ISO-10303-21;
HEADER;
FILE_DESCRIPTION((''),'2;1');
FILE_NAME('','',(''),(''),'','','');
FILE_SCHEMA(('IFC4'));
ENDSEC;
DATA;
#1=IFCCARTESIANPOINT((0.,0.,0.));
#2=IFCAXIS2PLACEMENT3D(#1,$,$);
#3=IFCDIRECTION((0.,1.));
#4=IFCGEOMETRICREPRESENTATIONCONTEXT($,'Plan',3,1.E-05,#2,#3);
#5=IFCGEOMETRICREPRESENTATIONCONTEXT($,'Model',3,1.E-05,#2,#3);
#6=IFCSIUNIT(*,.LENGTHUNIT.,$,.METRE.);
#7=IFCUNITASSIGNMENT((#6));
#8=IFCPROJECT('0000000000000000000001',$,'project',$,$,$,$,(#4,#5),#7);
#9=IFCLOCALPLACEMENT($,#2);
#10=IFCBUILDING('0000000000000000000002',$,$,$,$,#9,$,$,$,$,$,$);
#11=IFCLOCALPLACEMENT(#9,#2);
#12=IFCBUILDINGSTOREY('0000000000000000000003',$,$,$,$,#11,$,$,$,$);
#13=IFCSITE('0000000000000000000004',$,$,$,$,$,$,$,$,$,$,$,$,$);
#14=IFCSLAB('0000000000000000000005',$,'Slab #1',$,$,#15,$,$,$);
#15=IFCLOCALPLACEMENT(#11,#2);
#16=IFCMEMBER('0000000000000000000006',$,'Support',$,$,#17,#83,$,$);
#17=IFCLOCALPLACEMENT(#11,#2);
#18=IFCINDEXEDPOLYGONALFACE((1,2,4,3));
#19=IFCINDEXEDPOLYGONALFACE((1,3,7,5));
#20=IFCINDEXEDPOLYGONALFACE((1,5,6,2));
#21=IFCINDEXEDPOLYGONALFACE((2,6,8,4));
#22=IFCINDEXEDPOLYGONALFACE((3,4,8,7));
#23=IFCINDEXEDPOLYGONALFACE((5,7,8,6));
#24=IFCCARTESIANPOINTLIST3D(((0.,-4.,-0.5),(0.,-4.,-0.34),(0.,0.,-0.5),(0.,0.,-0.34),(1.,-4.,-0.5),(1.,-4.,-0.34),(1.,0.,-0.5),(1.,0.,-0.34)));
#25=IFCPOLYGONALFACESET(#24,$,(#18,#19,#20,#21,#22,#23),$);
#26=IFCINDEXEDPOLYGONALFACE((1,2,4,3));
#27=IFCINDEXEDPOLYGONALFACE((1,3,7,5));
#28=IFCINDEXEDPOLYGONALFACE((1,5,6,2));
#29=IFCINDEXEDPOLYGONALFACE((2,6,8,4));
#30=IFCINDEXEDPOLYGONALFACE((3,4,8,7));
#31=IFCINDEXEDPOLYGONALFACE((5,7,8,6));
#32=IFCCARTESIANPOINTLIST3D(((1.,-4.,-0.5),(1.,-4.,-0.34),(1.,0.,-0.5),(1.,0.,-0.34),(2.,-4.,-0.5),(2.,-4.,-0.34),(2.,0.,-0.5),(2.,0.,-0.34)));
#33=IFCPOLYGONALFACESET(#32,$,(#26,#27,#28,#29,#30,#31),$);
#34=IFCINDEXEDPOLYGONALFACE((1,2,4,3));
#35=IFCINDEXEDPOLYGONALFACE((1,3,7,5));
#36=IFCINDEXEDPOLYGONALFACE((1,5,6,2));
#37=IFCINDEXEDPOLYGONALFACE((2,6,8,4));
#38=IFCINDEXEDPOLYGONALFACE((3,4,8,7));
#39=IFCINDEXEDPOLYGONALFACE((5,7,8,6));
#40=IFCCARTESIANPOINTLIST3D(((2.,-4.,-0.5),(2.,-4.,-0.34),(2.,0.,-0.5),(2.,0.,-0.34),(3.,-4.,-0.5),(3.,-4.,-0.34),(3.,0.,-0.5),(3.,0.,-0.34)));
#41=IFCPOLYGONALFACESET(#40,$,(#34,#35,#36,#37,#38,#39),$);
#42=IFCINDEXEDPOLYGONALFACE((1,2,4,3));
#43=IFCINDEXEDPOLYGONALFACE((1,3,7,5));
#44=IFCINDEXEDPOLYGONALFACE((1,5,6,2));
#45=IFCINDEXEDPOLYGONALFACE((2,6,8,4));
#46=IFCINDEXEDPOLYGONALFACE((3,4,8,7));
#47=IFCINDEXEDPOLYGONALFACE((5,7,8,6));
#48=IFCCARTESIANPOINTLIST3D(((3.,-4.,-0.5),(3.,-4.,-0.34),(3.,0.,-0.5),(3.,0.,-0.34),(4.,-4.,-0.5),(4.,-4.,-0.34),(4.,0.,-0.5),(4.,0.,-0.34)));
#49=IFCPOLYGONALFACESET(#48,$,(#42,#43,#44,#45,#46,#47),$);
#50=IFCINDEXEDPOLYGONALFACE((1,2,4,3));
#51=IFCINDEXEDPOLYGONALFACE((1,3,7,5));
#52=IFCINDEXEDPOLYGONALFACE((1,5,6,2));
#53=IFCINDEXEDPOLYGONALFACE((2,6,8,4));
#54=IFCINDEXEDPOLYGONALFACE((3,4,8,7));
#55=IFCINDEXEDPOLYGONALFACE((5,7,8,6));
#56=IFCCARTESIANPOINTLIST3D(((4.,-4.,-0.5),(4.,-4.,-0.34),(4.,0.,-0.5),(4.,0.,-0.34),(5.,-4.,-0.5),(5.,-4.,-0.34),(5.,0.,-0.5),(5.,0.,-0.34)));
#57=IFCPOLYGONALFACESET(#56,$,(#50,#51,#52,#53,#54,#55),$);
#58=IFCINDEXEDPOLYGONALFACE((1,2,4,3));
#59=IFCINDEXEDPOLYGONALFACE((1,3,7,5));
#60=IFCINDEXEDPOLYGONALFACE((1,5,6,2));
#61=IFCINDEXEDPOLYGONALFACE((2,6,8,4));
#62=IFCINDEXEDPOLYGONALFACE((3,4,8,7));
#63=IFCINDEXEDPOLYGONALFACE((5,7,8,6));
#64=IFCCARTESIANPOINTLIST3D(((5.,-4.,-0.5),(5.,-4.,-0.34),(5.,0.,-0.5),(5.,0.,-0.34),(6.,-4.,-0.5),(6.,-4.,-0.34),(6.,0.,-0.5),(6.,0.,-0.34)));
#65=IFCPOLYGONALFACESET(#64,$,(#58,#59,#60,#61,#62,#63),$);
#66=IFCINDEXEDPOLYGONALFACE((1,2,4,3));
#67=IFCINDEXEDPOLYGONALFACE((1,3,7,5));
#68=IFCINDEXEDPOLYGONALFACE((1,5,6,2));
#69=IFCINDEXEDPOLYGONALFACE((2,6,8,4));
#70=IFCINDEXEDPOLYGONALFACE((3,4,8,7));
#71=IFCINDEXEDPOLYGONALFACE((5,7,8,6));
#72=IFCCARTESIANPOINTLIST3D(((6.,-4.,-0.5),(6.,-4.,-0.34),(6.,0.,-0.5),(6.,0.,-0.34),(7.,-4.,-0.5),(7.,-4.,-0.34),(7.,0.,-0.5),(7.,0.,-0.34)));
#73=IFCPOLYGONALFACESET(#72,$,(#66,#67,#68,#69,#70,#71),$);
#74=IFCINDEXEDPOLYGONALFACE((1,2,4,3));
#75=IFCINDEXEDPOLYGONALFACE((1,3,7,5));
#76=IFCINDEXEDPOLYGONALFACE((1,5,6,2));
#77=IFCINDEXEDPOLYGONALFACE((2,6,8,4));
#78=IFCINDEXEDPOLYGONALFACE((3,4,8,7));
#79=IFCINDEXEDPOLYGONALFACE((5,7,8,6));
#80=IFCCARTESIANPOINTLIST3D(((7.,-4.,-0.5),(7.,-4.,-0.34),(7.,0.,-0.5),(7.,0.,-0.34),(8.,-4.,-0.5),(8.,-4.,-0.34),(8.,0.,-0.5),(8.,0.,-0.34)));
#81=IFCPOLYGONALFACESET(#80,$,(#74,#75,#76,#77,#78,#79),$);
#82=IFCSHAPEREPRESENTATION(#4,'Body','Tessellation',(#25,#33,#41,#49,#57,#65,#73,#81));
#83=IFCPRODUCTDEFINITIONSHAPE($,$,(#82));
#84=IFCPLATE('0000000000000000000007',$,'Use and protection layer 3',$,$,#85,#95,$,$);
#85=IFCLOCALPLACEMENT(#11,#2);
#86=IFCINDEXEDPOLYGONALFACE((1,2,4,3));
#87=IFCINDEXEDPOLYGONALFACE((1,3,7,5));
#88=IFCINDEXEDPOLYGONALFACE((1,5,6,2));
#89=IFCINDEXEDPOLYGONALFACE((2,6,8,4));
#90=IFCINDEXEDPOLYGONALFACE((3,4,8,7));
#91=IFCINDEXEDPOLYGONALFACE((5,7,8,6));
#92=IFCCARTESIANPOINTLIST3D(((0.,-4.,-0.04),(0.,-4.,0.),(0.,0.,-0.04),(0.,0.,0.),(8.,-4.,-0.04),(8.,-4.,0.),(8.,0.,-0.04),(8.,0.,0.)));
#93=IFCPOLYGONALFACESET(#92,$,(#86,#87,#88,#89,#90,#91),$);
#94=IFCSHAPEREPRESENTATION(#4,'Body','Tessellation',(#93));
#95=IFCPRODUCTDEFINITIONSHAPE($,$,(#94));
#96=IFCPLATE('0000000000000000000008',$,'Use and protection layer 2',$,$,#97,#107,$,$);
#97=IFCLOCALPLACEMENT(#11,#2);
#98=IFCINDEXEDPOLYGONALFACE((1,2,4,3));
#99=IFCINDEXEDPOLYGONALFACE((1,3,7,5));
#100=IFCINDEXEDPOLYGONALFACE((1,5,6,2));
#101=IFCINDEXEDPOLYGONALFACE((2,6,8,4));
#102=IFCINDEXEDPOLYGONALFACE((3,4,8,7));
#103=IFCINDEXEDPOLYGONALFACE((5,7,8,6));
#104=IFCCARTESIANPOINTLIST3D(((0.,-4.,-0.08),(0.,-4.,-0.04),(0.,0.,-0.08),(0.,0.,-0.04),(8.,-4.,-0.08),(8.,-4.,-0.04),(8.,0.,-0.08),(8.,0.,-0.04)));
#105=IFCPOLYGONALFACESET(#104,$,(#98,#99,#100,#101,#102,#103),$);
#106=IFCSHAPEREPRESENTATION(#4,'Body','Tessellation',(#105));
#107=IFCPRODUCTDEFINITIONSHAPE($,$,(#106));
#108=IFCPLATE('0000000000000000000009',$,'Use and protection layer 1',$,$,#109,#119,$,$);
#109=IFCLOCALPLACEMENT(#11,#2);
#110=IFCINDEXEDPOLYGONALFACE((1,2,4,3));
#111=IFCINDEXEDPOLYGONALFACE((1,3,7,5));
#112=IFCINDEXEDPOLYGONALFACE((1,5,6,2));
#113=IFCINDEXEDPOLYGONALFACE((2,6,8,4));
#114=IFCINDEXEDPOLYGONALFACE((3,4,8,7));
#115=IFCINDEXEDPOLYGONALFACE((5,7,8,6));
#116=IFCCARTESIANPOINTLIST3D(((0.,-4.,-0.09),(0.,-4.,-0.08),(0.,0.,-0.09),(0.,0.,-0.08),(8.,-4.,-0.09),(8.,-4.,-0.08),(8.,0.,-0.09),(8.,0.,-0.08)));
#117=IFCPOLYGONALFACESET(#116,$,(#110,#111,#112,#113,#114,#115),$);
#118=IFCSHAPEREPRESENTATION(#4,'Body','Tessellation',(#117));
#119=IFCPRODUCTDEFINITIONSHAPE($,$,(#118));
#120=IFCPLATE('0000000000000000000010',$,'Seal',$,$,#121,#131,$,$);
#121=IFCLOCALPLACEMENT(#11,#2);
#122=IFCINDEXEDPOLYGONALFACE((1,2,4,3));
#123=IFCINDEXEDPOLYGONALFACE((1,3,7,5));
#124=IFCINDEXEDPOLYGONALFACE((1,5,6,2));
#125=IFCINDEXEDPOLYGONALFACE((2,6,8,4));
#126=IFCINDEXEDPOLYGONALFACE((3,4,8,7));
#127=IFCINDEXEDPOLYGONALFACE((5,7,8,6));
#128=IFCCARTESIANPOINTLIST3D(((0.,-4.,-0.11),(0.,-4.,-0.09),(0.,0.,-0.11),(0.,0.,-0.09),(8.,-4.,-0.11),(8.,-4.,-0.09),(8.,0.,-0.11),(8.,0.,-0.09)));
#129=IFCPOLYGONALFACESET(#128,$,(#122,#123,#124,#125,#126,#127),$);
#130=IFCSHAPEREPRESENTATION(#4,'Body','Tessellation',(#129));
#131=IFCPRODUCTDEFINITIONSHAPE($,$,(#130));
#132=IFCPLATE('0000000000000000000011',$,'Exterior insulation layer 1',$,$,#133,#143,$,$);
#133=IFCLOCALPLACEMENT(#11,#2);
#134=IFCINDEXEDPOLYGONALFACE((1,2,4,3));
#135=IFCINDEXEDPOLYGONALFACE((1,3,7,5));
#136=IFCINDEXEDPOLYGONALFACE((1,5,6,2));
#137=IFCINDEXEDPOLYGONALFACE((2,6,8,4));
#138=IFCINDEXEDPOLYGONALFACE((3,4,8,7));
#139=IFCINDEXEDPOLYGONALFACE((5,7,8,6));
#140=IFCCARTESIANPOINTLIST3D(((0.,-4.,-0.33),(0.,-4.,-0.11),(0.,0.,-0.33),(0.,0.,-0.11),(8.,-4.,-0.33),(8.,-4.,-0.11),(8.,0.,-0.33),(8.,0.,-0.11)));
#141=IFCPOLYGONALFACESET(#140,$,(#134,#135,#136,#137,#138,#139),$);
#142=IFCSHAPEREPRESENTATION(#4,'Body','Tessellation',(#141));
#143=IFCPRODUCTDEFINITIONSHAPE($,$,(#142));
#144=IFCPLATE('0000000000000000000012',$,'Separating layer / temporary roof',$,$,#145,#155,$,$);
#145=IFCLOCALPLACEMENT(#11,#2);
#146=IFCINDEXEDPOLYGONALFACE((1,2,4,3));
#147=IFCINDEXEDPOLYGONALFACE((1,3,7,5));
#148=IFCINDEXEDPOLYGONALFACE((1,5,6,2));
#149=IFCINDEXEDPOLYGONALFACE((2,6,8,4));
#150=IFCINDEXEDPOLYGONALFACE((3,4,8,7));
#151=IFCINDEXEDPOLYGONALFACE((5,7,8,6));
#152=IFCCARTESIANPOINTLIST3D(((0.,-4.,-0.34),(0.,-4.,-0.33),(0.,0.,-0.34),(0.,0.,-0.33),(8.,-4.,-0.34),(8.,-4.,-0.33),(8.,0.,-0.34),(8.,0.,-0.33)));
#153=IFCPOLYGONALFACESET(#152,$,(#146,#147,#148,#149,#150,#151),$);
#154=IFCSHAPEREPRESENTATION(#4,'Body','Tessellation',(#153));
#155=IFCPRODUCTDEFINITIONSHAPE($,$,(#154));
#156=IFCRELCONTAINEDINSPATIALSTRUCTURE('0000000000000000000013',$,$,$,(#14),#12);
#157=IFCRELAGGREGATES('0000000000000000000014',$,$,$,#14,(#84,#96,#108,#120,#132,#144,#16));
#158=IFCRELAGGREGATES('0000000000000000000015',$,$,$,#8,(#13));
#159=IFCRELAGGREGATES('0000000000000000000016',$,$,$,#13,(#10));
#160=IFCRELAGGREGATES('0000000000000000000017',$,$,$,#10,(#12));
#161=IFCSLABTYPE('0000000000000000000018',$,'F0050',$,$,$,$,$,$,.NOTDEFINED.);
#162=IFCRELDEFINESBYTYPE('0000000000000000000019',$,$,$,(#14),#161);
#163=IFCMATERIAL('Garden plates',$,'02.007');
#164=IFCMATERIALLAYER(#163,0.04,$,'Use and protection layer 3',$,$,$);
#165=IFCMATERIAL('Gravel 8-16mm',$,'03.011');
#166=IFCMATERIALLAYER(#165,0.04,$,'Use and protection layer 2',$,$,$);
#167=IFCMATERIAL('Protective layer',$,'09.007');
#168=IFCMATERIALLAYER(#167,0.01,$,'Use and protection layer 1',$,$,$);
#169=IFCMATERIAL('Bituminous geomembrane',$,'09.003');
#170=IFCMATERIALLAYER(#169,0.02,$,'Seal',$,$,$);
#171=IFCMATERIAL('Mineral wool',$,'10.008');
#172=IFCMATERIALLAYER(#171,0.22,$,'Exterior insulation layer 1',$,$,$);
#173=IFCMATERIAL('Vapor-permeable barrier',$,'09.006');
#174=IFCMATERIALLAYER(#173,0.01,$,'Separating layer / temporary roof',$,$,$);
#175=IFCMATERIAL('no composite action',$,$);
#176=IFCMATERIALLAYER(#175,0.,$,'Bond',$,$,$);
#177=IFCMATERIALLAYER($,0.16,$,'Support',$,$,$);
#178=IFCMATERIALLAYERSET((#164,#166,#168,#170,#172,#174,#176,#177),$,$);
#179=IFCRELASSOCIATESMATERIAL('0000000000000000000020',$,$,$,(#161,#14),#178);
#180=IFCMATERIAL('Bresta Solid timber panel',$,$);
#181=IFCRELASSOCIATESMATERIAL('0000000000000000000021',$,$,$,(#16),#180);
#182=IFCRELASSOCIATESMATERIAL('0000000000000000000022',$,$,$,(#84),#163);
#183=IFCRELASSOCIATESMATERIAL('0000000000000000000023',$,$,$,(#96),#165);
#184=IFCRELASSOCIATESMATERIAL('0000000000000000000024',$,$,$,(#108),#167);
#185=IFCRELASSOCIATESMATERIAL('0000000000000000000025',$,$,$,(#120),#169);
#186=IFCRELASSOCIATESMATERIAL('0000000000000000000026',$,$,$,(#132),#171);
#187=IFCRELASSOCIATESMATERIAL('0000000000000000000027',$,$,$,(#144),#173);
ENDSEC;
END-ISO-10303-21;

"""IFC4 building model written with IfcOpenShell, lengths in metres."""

from ifc_helpers import new_model, si_unit, direction, frame, frame_2d, origin, origin_with_axes, place, context, project, spatial, rectangle, extrude, material, layer, layer_set, type_object, element, aggregate, save


model = new_model("IFC4")

# Units and contexts
plan_context = context("Plan", 3, precision=1e-05, world=origin(), true_north=direction((0.0, 1.0)))
model_context = context("Model", 3, precision=1e-05, world=origin(), true_north=direction((0.0, 1.0)))
ifc_project = project(units=[si_unit("LENGTHUNIT", "METRE")], contexts=[plan_context, model_context])

# Site, building, storey
site = spatial("IfcSite", under=ifc_project)
building_placement = place(None, origin())
building = spatial("IfcBuilding", under=site, at=building_placement)
storey_placement = place(building_placement, origin())
storey = spatial("IfcBuildingStorey", under=building, at=storey_placement)

# Slab, member, plates
ifc_material_1 = material(Name="Garden plates", Category="02.007")
ifc_layer_1 = layer(ifc_material_1, 0.04, Name="Use and protection layer 3")
ifc_material_2 = material(Name="Gravel 8-16mm", Category="03.011")
ifc_layer_2 = layer(ifc_material_2, 0.04, Name="Use and protection layer 2")
ifc_material_3 = material(Name="Protective layer", Category="09.007")
ifc_layer_3 = layer(ifc_material_3, 0.01, Name="Use and protection layer 1")
ifc_material_4 = material(Name="Bituminous geomembrane", Category="09.003")
ifc_layer_4 = layer(ifc_material_4, 0.02, Name="Seal")
ifc_material_5 = material(Name="Mineral wool", Category="10.008")
ifc_layer_5 = layer(ifc_material_5, 0.22, Name="Exterior insulation layer 1")
ifc_material_6 = material(Name="Vapor-permeable barrier", Category="09.006")
ifc_layer_6 = layer(ifc_material_6, 0.01, Name="Separating layer / temporary roof")
ifc_material_7 = material(Name="no composite action")
ifc_layer_7 = layer(ifc_material_7, 0.0, Name="Bond")
ifc_layer_8 = layer(None, 0.16, Name="Support")
ifc_layer_set = layer_set([ifc_layer_1, ifc_layer_2, ifc_layer_3, ifc_layer_4, ifc_layer_5, ifc_layer_6, ifc_layer_7, ifc_layer_8])
slab_type = type_object("IfcSlabType", Name="F0050", PredefinedType="NOTDEFINED", material=ifc_layer_set)
slab_placement = place(None, frame((0.0, 0.0, 0.0), z_axis=(0.0, 0.0, -1.0), x_axis=(1.0, 0.0, 0.0)))
slab = element("IfcSlab", 1, at=slab_placement, inside=storey, type_object=slab_type, material=ifc_layer_set, Name="Slab #1")
ifc_material_8 = material(Name="Bresta Solid timber panel")
member_placement = place(slab_placement, origin())
member = element("IfcMember", 2, at=member_placement, material=ifc_material_8, Name="Support", context=plan_context, shape_type="SweptSolid", body=[
    extrude(rectangle(XDim=1.0, YDim=0.16, at=frame_2d((0.5, 0.08), x_axis=(1.0, 0.0))), frame((0.0, 4.0, 0.34), z_axis=(0.0, -1.0, 0.0), x_axis=(1.0, 0.0, 0.0)), (0.0, 0.0, 1.0), 4.0),
    extrude(rectangle(XDim=1.0, YDim=0.16, at=frame_2d((0.5, 0.08), x_axis=(1.0, 0.0))), frame((1.0, 4.0, 0.34), z_axis=(0.0, -1.0, 0.0), x_axis=(1.0, 0.0, 0.0)), (0.0, 0.0, 1.0), 4.0),
    extrude(rectangle(XDim=1.0, YDim=0.16, at=frame_2d((0.5, 0.08), x_axis=(1.0, 0.0))), frame((2.0, 4.0, 0.34), z_axis=(0.0, -1.0, 0.0), x_axis=(1.0, 0.0, 0.0)), (0.0, 0.0, 1.0), 4.0),
    extrude(rectangle(XDim=1.0, YDim=0.16, at=frame_2d((0.5, 0.08), x_axis=(1.0, 0.0))), frame((3.0, 4.0, 0.34), z_axis=(0.0, -1.0, 0.0), x_axis=(1.0, 0.0, 0.0)), (0.0, 0.0, 1.0), 4.0),
    extrude(rectangle(XDim=1.0, YDim=0.16, at=frame_2d((0.5, 0.08), x_axis=(1.0, 0.0))), frame((4.0, 4.0, 0.34), z_axis=(0.0, -1.0, 0.0), x_axis=(1.0, 0.0, 0.0)), (0.0, 0.0, 1.0), 4.0),
    extrude(rectangle(XDim=1.0, YDim=0.16, at=frame_2d((0.5, 0.08), x_axis=(1.0, 0.0))), frame((5.0, 4.0, 0.34), z_axis=(0.0, -1.0, 0.0), x_axis=(1.0, 0.0, 0.0)), (0.0, 0.0, 1.0), 4.0),
    extrude(rectangle(XDim=1.0, YDim=0.16, at=frame_2d((0.5, 0.08), x_axis=(1.0, 0.0))), frame((6.0, 4.0, 0.34), z_axis=(0.0, -1.0, 0.0), x_axis=(1.0, 0.0, 0.0)), (0.0, 0.0, 1.0), 4.0),
    extrude(rectangle(XDim=1.0, YDim=0.16, at=frame_2d((0.5, 0.08), x_axis=(1.0, 0.0))), frame((7.0, 4.0, 0.34), z_axis=(0.0, -1.0, 0.0), x_axis=(1.0, 0.0, 0.0)), (0.0, 0.0, 1.0), 4.0),
])
plate_1_placement = place(slab_placement, origin())
plate_1 = element("IfcPlate", 3, at=plate_1_placement, material=ifc_material_1, Name="Use and protection layer 3", context=plan_context, shape_type="SweptSolid", body=[
    extrude(rectangle(XDim=8.0, YDim=4.0, at=frame_2d((4.0, 2.0), x_axis=(1.0, 0.0))), origin_with_axes(), (0.0, 0.0, 1.0), 0.04),
])
plate_2_placement = place(slab_placement, origin())
plate_2 = element("IfcPlate", 4, at=plate_2_placement, material=ifc_material_2, Name="Use and protection layer 2", context=plan_context, shape_type="SweptSolid", body=[
    extrude(rectangle(XDim=8.0, YDim=4.0, at=frame_2d((4.0, 2.0), x_axis=(1.0, 0.0))), frame((0.0, 0.0, 0.04), z_axis=(0.0, 0.0, 1.0), x_axis=(1.0, 0.0, 0.0)), (0.0, 0.0, 1.0), 0.04),
])
plate_3_placement = place(slab_placement, origin())
plate_3 = element("IfcPlate", 5, at=plate_3_placement, material=ifc_material_3, Name="Use and protection layer 1", context=plan_context, shape_type="SweptSolid", body=[
    extrude(rectangle(XDim=8.0, YDim=4.0, at=frame_2d((4.0, 2.0), x_axis=(1.0, 0.0))), frame((0.0, 0.0, 0.08), z_axis=(0.0, 0.0, 1.0), x_axis=(1.0, 0.0, 0.0)), (0.0, 0.0, 1.0), 0.01),
])
plate_4_placement = place(slab_placement, origin())
plate_4 = element("IfcPlate", 6, at=plate_4_placement, material=ifc_material_4, Name="Seal", context=plan_context, shape_type="SweptSolid", body=[
    extrude(rectangle(XDim=8.0, YDim=4.0, at=frame_2d((4.0, 2.0), x_axis=(1.0, 0.0))), frame((0.0, 0.0, 0.09), z_axis=(0.0, 0.0, 1.0), x_axis=(1.0, 0.0, 0.0)), (0.0, 0.0, 1.0), 0.02),
])
plate_5_placement = place(slab_placement, origin())
plate_5 = element("IfcPlate", 7, at=plate_5_placement, material=ifc_material_5, Name="Exterior insulation layer 1", context=plan_context, shape_type="SweptSolid", body=[
    extrude(rectangle(XDim=8.0, YDim=4.0, at=frame_2d((4.0, 2.0), x_axis=(1.0, 0.0))), frame((0.0, 0.0, 0.11), z_axis=(0.0, 0.0, 1.0), x_axis=(1.0, 0.0, 0.0)), (0.0, 0.0, 1.0), 0.22),
])
plate_6_placement = place(slab_placement, origin())
plate_6 = element("IfcPlate", 8, at=plate_6_placement, material=ifc_material_6, Name="Separating layer / temporary roof", context=plan_context, shape_type="SweptSolid", body=[
    extrude(rectangle(XDim=8.0, YDim=4.0, at=frame_2d((4.0, 2.0), x_axis=(1.0, 0.0))), frame((0.0, 0.0, 0.33), z_axis=(0.0, 0.0, 1.0), x_axis=(1.0, 0.0, 0.0)), (0.0, 0.0, 1.0), 0.01),
])
aggregate(slab, [plate_1, plate_2, plate_3, plate_4, plate_5, plate_6, member])

save(model, "model.ifc")
